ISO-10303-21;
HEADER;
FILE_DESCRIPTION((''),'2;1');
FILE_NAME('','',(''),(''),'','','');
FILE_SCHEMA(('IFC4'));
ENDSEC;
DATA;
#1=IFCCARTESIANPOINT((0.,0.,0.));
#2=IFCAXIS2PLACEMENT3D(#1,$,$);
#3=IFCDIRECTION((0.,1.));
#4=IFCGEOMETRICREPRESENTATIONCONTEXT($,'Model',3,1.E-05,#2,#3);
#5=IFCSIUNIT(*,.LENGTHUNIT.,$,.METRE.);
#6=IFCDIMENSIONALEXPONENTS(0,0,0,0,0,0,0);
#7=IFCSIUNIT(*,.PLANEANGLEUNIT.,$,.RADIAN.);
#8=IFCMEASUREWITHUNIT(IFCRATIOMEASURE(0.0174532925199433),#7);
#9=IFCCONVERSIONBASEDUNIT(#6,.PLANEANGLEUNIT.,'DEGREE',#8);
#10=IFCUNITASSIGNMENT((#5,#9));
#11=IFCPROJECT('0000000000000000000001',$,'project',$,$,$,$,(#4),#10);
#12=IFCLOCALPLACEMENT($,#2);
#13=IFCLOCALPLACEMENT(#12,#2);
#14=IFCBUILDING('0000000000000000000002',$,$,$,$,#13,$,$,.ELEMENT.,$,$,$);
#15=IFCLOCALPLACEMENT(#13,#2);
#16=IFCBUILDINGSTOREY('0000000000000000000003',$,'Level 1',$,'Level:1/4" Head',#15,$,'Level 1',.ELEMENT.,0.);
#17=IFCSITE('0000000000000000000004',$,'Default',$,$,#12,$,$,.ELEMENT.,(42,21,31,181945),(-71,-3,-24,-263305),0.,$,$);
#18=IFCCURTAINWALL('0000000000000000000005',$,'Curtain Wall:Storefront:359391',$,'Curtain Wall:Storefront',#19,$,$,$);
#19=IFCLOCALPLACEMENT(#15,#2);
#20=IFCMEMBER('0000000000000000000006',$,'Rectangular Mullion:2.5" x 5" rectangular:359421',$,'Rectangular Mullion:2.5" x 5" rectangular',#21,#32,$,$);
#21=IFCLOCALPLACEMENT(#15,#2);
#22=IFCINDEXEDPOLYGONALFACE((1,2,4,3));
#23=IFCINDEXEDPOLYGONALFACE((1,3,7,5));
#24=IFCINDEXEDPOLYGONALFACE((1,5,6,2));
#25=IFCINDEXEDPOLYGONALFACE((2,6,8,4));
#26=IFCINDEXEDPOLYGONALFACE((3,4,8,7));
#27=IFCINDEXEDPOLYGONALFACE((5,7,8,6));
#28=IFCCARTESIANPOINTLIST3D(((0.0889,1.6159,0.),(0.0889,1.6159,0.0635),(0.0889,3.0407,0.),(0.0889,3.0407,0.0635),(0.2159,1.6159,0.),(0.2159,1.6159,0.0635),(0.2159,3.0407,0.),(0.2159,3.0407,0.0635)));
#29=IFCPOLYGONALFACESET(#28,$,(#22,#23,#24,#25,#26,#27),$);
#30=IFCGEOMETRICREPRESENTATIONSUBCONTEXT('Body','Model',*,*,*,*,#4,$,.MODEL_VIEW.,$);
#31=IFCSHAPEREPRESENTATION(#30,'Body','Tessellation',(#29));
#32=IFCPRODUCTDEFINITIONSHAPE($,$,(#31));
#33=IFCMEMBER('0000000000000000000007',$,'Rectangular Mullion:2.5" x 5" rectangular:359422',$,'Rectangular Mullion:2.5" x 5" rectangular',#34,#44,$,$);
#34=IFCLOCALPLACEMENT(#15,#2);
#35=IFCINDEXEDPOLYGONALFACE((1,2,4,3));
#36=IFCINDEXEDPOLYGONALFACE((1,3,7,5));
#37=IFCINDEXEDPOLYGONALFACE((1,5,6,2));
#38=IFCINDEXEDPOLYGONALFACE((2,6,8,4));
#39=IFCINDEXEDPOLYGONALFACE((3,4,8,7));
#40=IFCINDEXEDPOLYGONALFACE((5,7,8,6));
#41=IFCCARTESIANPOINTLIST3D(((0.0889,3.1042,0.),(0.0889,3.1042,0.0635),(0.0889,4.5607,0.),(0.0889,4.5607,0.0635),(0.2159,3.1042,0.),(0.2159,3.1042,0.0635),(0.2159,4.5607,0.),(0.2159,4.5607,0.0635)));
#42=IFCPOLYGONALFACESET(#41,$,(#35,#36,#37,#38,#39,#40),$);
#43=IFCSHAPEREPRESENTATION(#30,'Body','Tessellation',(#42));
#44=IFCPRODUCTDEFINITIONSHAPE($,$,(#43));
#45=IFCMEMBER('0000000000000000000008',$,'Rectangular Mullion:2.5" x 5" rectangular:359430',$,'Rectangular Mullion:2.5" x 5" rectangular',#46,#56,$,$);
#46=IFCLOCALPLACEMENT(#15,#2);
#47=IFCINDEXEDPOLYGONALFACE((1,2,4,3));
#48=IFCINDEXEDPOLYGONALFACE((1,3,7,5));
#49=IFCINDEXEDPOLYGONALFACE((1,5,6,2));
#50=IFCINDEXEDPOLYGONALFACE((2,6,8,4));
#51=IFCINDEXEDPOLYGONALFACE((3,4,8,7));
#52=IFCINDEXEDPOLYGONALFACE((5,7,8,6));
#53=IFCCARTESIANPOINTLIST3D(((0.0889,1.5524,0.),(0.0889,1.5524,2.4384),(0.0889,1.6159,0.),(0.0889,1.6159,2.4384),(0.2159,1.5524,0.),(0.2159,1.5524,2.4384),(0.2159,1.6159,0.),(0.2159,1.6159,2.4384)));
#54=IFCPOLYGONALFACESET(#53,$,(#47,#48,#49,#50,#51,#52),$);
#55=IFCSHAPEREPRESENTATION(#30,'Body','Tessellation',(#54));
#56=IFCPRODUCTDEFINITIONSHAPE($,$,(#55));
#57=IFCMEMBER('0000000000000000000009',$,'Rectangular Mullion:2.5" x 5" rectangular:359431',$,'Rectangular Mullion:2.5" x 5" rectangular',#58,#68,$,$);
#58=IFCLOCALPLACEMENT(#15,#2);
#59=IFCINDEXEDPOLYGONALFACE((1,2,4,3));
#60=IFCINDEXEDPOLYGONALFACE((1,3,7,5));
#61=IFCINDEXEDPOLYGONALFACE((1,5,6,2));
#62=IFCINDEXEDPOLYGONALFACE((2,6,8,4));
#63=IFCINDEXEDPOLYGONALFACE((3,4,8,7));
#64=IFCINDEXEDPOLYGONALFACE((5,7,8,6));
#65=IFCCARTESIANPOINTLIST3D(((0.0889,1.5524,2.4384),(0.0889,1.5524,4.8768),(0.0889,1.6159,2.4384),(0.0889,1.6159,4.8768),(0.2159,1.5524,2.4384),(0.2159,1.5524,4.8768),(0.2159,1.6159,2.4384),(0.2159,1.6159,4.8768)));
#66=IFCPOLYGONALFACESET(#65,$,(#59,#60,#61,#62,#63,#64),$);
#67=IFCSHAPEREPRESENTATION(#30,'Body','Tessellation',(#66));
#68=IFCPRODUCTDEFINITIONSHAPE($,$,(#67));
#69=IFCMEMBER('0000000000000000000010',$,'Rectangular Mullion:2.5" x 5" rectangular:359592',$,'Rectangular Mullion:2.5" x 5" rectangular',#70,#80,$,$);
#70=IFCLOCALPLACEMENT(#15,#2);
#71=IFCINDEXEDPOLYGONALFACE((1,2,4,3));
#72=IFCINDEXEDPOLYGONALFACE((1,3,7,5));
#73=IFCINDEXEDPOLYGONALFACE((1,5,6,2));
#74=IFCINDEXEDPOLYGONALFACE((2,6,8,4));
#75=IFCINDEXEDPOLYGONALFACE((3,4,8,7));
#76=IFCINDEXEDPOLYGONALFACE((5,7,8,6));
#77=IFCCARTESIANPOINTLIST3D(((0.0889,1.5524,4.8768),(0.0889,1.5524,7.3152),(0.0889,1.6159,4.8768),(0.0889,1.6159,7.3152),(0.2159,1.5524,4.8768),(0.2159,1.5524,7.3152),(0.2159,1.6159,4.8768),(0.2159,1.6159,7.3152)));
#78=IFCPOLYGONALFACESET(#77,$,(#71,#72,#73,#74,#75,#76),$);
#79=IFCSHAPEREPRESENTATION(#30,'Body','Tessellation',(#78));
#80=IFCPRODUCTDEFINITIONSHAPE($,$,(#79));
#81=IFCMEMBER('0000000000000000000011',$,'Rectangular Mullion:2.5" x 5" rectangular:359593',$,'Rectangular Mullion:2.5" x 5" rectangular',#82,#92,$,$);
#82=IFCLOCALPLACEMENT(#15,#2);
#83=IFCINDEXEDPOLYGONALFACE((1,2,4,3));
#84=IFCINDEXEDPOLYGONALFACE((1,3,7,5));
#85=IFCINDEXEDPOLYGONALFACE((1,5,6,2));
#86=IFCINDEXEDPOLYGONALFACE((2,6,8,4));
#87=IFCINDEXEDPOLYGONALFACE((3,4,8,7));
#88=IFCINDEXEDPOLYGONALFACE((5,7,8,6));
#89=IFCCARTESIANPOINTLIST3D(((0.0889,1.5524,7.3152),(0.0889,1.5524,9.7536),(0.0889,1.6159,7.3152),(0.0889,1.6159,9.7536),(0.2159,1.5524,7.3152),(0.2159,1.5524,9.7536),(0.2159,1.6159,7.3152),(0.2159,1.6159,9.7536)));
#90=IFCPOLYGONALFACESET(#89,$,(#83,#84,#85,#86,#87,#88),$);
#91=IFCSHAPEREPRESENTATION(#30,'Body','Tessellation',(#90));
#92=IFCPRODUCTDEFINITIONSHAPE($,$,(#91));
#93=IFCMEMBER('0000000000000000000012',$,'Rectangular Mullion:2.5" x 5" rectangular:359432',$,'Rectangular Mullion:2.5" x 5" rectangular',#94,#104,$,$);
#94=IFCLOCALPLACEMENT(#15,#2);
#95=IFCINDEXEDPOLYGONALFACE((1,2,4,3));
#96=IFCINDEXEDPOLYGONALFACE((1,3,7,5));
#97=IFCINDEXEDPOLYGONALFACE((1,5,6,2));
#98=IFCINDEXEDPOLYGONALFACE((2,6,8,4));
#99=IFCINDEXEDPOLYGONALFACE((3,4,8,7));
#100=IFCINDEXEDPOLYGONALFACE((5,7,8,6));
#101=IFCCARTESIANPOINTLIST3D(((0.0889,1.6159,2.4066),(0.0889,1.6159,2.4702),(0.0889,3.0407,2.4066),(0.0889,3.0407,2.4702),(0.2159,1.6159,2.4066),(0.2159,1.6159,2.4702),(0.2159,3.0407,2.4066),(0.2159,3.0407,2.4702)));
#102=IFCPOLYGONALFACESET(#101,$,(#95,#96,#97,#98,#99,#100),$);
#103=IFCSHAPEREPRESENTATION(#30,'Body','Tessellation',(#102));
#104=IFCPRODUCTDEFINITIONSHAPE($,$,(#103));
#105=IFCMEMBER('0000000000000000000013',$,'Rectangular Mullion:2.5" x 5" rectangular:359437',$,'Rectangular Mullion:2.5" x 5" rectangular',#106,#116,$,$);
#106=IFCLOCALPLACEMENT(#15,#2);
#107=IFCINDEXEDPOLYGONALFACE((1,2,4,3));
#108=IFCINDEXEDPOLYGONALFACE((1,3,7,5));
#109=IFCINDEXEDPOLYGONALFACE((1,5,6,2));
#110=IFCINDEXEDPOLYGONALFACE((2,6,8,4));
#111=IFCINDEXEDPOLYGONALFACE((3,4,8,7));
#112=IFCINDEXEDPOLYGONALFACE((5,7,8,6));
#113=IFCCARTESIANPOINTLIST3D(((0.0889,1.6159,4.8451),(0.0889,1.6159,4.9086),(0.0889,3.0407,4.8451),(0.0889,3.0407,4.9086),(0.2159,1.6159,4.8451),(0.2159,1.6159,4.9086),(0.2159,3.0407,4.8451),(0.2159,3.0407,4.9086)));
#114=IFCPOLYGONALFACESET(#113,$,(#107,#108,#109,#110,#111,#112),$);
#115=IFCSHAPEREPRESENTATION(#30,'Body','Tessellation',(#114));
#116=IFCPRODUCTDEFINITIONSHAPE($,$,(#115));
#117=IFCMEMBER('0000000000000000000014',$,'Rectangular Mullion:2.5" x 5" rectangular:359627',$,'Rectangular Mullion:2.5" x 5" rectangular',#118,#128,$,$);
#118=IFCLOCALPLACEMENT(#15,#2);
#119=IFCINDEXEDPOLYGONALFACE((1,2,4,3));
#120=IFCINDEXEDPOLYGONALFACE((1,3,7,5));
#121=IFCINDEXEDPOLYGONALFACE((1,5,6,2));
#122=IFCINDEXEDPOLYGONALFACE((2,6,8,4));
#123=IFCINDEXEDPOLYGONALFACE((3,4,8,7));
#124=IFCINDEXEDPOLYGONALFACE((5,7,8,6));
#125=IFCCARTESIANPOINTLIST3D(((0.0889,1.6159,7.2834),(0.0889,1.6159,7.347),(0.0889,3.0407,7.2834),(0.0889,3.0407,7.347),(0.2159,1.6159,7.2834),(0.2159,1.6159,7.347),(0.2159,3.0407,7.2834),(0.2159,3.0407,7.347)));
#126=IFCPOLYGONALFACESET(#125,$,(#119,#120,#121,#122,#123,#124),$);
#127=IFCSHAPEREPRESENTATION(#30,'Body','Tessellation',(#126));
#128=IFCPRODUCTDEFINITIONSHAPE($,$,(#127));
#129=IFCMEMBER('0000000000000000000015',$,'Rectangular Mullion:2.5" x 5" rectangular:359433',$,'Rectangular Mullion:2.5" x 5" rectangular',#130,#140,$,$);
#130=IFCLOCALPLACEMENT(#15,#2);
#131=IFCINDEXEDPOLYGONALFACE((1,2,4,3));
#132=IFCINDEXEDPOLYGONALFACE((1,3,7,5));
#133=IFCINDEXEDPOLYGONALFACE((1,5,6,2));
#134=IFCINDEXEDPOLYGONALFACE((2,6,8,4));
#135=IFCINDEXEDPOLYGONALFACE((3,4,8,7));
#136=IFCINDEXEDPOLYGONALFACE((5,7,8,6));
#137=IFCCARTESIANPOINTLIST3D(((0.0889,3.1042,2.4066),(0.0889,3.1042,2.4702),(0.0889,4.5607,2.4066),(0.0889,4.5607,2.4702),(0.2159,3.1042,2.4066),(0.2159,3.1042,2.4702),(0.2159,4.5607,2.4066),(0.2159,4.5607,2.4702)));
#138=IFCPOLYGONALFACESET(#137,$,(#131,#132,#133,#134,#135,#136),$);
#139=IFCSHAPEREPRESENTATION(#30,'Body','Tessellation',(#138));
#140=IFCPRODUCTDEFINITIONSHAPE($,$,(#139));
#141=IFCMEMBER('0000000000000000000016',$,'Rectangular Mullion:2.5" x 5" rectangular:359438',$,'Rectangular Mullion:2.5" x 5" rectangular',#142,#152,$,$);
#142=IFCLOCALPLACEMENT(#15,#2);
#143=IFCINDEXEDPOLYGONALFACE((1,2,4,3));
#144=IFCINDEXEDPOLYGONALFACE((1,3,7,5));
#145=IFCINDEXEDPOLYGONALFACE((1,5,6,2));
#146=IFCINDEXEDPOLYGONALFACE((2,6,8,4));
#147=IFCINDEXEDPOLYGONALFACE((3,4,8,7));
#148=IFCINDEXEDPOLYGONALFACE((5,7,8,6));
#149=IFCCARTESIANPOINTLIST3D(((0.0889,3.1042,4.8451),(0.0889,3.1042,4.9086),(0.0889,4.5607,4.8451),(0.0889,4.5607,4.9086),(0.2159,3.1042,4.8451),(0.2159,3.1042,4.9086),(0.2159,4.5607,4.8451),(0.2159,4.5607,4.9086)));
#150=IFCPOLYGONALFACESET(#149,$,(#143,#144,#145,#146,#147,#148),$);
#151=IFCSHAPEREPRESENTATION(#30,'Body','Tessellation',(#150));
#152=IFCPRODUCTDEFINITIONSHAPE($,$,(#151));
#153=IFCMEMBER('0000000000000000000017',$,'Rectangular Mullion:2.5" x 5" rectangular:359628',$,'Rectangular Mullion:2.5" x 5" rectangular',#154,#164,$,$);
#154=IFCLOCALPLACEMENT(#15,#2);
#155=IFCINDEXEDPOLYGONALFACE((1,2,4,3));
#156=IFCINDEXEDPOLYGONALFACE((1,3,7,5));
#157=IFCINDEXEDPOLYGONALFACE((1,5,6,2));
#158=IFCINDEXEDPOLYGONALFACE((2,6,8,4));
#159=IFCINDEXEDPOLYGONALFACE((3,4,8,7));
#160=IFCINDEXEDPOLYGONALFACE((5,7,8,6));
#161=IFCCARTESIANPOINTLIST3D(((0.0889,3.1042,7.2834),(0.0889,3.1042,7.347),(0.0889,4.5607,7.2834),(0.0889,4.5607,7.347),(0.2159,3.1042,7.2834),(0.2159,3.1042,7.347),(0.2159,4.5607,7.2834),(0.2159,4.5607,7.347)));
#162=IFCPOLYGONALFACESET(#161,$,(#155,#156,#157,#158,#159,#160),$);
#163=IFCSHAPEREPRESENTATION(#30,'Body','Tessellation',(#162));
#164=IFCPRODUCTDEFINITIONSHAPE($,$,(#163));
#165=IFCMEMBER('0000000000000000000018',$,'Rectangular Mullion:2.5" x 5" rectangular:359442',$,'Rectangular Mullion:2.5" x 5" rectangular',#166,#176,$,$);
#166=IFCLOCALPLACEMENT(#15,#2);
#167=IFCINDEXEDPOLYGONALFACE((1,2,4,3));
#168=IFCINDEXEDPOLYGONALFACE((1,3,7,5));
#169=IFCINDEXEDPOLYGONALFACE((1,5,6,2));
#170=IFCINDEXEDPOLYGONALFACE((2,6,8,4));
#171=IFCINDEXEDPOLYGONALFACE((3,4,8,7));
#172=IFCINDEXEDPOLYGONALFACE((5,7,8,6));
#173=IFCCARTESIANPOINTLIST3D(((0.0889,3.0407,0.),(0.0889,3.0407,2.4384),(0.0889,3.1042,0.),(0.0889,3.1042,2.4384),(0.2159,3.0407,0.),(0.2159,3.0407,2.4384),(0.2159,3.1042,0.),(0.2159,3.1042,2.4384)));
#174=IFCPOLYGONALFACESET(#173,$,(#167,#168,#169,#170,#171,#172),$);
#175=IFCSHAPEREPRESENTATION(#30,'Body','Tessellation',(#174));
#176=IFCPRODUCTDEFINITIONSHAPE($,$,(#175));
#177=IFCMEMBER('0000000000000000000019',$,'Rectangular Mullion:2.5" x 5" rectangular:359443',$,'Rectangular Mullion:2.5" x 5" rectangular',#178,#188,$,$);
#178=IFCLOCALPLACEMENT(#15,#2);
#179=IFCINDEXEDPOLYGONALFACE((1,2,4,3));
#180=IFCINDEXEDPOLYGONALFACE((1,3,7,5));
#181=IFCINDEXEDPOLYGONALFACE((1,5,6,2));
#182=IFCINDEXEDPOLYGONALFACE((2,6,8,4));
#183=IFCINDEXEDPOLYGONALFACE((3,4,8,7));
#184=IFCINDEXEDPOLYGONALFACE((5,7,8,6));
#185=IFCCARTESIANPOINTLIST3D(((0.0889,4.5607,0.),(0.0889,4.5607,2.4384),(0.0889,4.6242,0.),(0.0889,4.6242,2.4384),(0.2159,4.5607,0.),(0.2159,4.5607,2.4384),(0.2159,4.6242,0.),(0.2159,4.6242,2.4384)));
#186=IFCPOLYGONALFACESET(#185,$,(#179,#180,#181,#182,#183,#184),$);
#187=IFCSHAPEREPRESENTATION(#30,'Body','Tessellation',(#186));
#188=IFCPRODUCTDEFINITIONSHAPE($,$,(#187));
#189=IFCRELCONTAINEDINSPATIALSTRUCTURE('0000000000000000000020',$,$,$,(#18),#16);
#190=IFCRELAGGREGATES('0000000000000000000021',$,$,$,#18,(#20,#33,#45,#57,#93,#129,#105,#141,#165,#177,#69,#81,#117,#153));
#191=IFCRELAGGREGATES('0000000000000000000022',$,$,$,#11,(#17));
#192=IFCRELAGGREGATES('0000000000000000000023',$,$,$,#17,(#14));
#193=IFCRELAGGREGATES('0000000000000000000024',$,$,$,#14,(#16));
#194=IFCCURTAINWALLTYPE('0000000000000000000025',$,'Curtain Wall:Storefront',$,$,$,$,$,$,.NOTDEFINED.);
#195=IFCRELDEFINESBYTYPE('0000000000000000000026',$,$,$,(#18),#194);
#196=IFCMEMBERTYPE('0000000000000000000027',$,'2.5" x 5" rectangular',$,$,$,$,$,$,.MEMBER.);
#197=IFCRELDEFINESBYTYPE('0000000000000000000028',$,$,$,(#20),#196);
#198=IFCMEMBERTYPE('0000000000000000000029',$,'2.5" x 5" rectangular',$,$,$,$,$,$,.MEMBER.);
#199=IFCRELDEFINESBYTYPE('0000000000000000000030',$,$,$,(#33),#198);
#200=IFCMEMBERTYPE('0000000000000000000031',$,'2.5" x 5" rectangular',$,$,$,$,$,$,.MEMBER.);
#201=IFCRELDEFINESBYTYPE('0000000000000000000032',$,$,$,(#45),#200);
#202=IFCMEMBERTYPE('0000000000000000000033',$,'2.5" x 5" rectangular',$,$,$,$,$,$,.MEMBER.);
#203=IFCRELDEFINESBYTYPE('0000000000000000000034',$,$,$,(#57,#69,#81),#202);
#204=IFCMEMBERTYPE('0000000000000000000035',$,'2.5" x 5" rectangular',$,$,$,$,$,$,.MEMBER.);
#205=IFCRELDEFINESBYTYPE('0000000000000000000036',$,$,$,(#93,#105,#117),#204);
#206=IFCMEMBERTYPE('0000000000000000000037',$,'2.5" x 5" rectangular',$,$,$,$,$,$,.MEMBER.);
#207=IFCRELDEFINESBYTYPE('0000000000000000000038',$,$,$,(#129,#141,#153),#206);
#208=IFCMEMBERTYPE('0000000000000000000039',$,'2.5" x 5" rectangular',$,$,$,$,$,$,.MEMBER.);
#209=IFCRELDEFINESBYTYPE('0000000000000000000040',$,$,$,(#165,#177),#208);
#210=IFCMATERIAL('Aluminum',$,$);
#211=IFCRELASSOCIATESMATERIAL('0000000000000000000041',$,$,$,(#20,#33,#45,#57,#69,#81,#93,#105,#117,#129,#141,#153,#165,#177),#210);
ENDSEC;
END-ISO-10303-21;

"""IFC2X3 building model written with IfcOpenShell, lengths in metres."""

from ifc_helpers import new_model, entity, si_unit, converted_unit, direction, frame, origin, origin_2d_with_axis, place, context, subcontext, project, spatial, rectangle, extrude, source, transform, mapped, material, type_object, type_shapes, element, aggregate, save


model = new_model("IFC2X3")

# Units and contexts
model_context = context("Model", 3, precision=1e-05, world=origin(), true_north=direction((0.0, 1.0)))
body_context = subcontext(model_context, "Body", "Model", "MODEL_VIEW")
ifc_project = project(units=[si_unit("LENGTHUNIT", "METRE"), converted_unit("PLANEANGLEUNIT", "DEGREE", entity("IfcRatioMeasure", 0.0174532925199433), si_unit("PLANEANGLEUNIT", "RADIAN"), dimensions=[0, 0, 0, 0, 0, 0, 0])], contexts=[model_context])

# Site, building, storey
site_placement = place(None, origin())
site = spatial("IfcSite", under=ifc_project, at=site_placement, Name="Default", CompositionType="ELEMENT", RefLatitude=(42, 21, 31, 181945), RefLongitude=(-71, -3, -24, -263305), RefElevation=0.0)
building_placement = place(site_placement, origin())
building = spatial("IfcBuilding", under=site, at=building_placement, CompositionType="ELEMENT")
storey_placement = place(building_placement, origin())
storey = spatial("IfcBuildingStorey", under=building, at=storey_placement, Name="Level 1", ObjectType="Level:1/4\" Head", LongName="Level 1", CompositionType="ELEMENT", Elevation=0.0)

# Curtain wall, members
curtain_wall_type = type_object("IfcCurtainWallType", Name="Curtain Wall:Storefront", PredefinedType="NOTDEFINED")
curtain_wall_placement = place(storey_placement, origin())
curtain_wall = element("IfcCurtainWall", 1, at=curtain_wall_placement, inside=storey, type_object=curtain_wall_type, Name="Curtain Wall:Storefront:359391", ObjectType="Curtain Wall:Storefront")
ifc_material_1 = material(Name="Aluminum")
member_type_1 = type_object("IfcMemberType", Name="2.5\" x 5\" rectangular", PredefinedType="MEMBER")
shared_shape_1 = source(origin(), body_context, "Body", "SweptSolid", [
    extrude(rectangle(XDim=0.127, YDim=0.0635, at=origin_2d_with_axis()), frame((-0.0318, 0.0, -1.4248), z_axis=(0.0, 0.0, 1.0), x_axis=(0.0, -1.0, 0.0)), (0.0, 0.0, 1.0), 1.4248),
])
type_shapes(member_type_1, [shared_shape_1])
member_1_placement = place(storey_placement, frame((0.1524, 1.6159, 0.0), z_axis=(0.0, -1.0, 0.0), x_axis=(0.0, 0.0, -1.0)))
member_1 = element("IfcMember", 2, at=member_1_placement, type_object=member_type_1, material=ifc_material_1, Name="Rectangular Mullion:2.5\" x 5\" rectangular:359421", ObjectType="Rectangular Mullion:2.5\" x 5\" rectangular", context=body_context, shape_type="MappedRepresentation", body=[
    mapped(shared_shape_1, transform((0.0, 0.0, 0.0), scale=1.0)),
])
member_type_2 = type_object("IfcMemberType", Name="2.5\" x 5\" rectangular", PredefinedType="MEMBER")
shared_shape_2 = source(origin(), body_context, "Body", "SweptSolid", [
    extrude(rectangle(XDim=0.127, YDim=0.0635, at=origin_2d_with_axis()), frame((-0.0318, 0.0, -1.4565), z_axis=(0.0, 0.0, 1.0), x_axis=(0.0, -1.0, 0.0)), (0.0, 0.0, 1.0), 1.4565),
])
type_shapes(member_type_2, [shared_shape_2])
member_2_placement = place(storey_placement, frame((0.1524, 3.1042, 0.0), z_axis=(0.0, -1.0, 0.0), x_axis=(0.0, 0.0, -1.0)))
member_2 = element("IfcMember", 3, at=member_2_placement, type_object=member_type_2, material=ifc_material_1, Name="Rectangular Mullion:2.5\" x 5\" rectangular:359422", ObjectType="Rectangular Mullion:2.5\" x 5\" rectangular", context=body_context, shape_type="MappedRepresentation", body=[
    mapped(shared_shape_2, transform((0.0, 0.0, 0.0), scale=1.0)),
])
member_type_3 = type_object("IfcMemberType", Name="2.5\" x 5\" rectangular", PredefinedType="MEMBER")
shared_shape_3 = source(origin(), body_context, "Body", "SweptSolid", [
    extrude(rectangle(XDim=0.127, YDim=0.0635, at=origin_2d_with_axis()), frame((-0.0318, 0.0, -2.4384), z_axis=(0.0, 0.0, 1.0), x_axis=(0.0, -1.0, 0.0)), (0.0, 0.0, 1.0), 2.4384),
])
type_shapes(member_type_3, [shared_shape_3])
member_3_placement = place(storey_placement, frame((0.1524, 1.5524, 2.4384), z_axis=(0.0, 0.0, 1.0), x_axis=(0.0, -1.0, 0.0)))
member_3 = element("IfcMember", 4, at=member_3_placement, type_object=member_type_3, material=ifc_material_1, Name="Rectangular Mullion:2.5\" x 5\" rectangular:359430", ObjectType="Rectangular Mullion:2.5\" x 5\" rectangular", context=body_context, shape_type="MappedRepresentation", body=[
    mapped(shared_shape_3, transform((0.0, 0.0, 0.0), scale=1.0)),
])
member_type_4 = type_object("IfcMemberType", Name="2.5\" x 5\" rectangular", PredefinedType="MEMBER")
shared_shape_4 = source(origin(), body_context, "Body", "SweptSolid", [
    extrude(rectangle(XDim=0.127, YDim=0.0635, at=origin_2d_with_axis()), frame((-0.0318, 0.0, -2.4384), z_axis=(0.0, 0.0, 1.0), x_axis=(0.0, -1.0, 0.0)), (0.0, 0.0, 1.0), 2.4384),
])
type_shapes(member_type_4, [shared_shape_4])
member_4_placement = place(storey_placement, frame((0.1524, 1.5524, 4.8768), z_axis=(0.0, 0.0, 1.0), x_axis=(0.0, -1.0, 0.0)))
member_4 = element("IfcMember", 5, at=member_4_placement, type_object=member_type_4, material=ifc_material_1, Name="Rectangular Mullion:2.5\" x 5\" rectangular:359431", ObjectType="Rectangular Mullion:2.5\" x 5\" rectangular", context=body_context, shape_type="MappedRepresentation", body=[
    mapped(shared_shape_4, transform((0.0, 0.0, 0.0), scale=1.0)),
])
member_5_placement = place(storey_placement, frame((0.1524, 1.5524, 7.3152), z_axis=(0.0, 0.0, 1.0), x_axis=(0.0, -1.0, 0.0)))
member_5 = element("IfcMember", 6, at=member_5_placement, type_object=member_type_4, material=ifc_material_1, Name="Rectangular Mullion:2.5\" x 5\" rectangular:359592", ObjectType="Rectangular Mullion:2.5\" x 5\" rectangular", context=body_context, shape_type="MappedRepresentation", body=[
    mapped(shared_shape_4, transform((0.0, 0.0, 0.0), scale=1.0)),
])
member_6_placement = place(storey_placement, frame((0.1524, 1.5524, 9.7536), z_axis=(0.0, 0.0, 1.0), x_axis=(0.0, -1.0, 0.0)))
member_6 = element("IfcMember", 7, at=member_6_placement, type_object=member_type_4, material=ifc_material_1, Name="Rectangular Mullion:2.5\" x 5\" rectangular:359593", ObjectType="Rectangular Mullion:2.5\" x 5\" rectangular", context=body_context, shape_type="MappedRepresentation", body=[
    mapped(shared_shape_4, transform((0.0, 0.0, 0.0), scale=1.0)),
])
member_type_5 = type_object("IfcMemberType", Name="2.5\" x 5\" rectangular", PredefinedType="MEMBER")
shared_shape_5 = source(origin(), body_context, "Body", "SweptSolid", [
    extrude(rectangle(XDim=0.127, YDim=0.0635, at=origin_2d_with_axis()), frame((0.0, 0.0, -1.4248), z_axis=(0.0, 0.0, 1.0), x_axis=(0.0, -1.0, 0.0)), (0.0, 0.0, 1.0), 1.4248),
])
type_shapes(member_type_5, [shared_shape_5])
member_7_placement = place(storey_placement, frame((0.1524, 3.0407, 2.4384), z_axis=(0.0, 1.0, 0.0), x_axis=(0.0, 0.0, 1.0)))
member_7 = element("IfcMember", 8, at=member_7_placement, type_object=member_type_5, material=ifc_material_1, Name="Rectangular Mullion:2.5\" x 5\" rectangular:359432", ObjectType="Rectangular Mullion:2.5\" x 5\" rectangular", context=body_context, shape_type="MappedRepresentation", body=[
    mapped(shared_shape_5, transform((0.0, 0.0, 0.0), scale=1.0)),
])
member_8_placement = place(storey_placement, frame((0.1524, 3.0407, 4.8768), z_axis=(0.0, 1.0, 0.0), x_axis=(0.0, 0.0, 1.0)))
member_8 = element("IfcMember", 9, at=member_8_placement, type_object=member_type_5, material=ifc_material_1, Name="Rectangular Mullion:2.5\" x 5\" rectangular:359437", ObjectType="Rectangular Mullion:2.5\" x 5\" rectangular", context=body_context, shape_type="MappedRepresentation", body=[
    mapped(shared_shape_5, transform((0.0, 0.0, 0.0), scale=1.0)),
])
member_9_placement = place(storey_placement, frame((0.1524, 3.0407, 7.3152), z_axis=(0.0, 1.0, 0.0), x_axis=(0.0, 0.0, 1.0)))
member_9 = element("IfcMember", 10, at=member_9_placement, type_object=member_type_5, material=ifc_material_1, Name="Rectangular Mullion:2.5\" x 5\" rectangular:359627", ObjectType="Rectangular Mullion:2.5\" x 5\" rectangular", context=body_context, shape_type="MappedRepresentation", body=[
    mapped(shared_shape_5, transform((0.0, 0.0, 0.0), scale=1.0)),
])
member_type_6 = type_object("IfcMemberType", Name="2.5\" x 5\" rectangular", PredefinedType="MEMBER")
shared_shape_6 = source(origin(), body_context, "Body", "SweptSolid", [
    extrude(rectangle(XDim=0.127, YDim=0.0635, at=origin_2d_with_axis()), frame((0.0, 0.0, -1.4565), z_axis=(0.0, 0.0, 1.0), x_axis=(0.0, -1.0, 0.0)), (0.0, 0.0, 1.0), 1.4565),
])
type_shapes(member_type_6, [shared_shape_6])
member_10_placement = place(storey_placement, frame((0.1524, 4.5607, 2.4384), z_axis=(0.0, 1.0, 0.0), x_axis=(0.0, 0.0, 1.0)))
member_10 = element("IfcMember", 11, at=member_10_placement, type_object=member_type_6, material=ifc_material_1, Name="Rectangular Mullion:2.5\" x 5\" rectangular:359433", ObjectType="Rectangular Mullion:2.5\" x 5\" rectangular", context=body_context, shape_type="MappedRepresentation", body=[
    mapped(shared_shape_6, transform((0.0, 0.0, 0.0), scale=1.0)),
])
member_11_placement = place(storey_placement, frame((0.1524, 4.5607, 4.8768), z_axis=(0.0, 1.0, 0.0), x_axis=(0.0, 0.0, 1.0)))
member_11 = element("IfcMember", 12, at=member_11_placement, type_object=member_type_6, material=ifc_material_1, Name="Rectangular Mullion:2.5\" x 5\" rectangular:359438", ObjectType="Rectangular Mullion:2.5\" x 5\" rectangular", context=body_context, shape_type="MappedRepresentation", body=[
    mapped(shared_shape_6, transform((0.0, 0.0, 0.0), scale=1.0)),
])
member_12_placement = place(storey_placement, frame((0.1524, 4.5607, 7.3152), z_axis=(0.0, 1.0, 0.0), x_axis=(0.0, 0.0, 1.0)))
member_12 = element("IfcMember", 13, at=member_12_placement, type_object=member_type_6, material=ifc_material_1, Name="Rectangular Mullion:2.5\" x 5\" rectangular:359628", ObjectType="Rectangular Mullion:2.5\" x 5\" rectangular", context=body_context, shape_type="MappedRepresentation", body=[
    mapped(shared_shape_6, transform((0.0, 0.0, 0.0), scale=1.0)),
])
member_type_7 = type_object("IfcMemberType", Name="2.5\" x 5\" rectangular", PredefinedType="MEMBER")
shared_shape_7 = source(origin(), body_context, "Body", "SweptSolid", [
    extrude(rectangle(XDim=0.127, YDim=0.0635, at=origin_2d_with_axis()), frame((0.0, 0.0, -2.4384), z_axis=(0.0, 0.0, 1.0), x_axis=(0.0, -1.0, 0.0)), (0.0, 0.0, 1.0), 2.4384),
])
type_shapes(member_type_7, [shared_shape_7])
member_13_placement = place(storey_placement, frame((0.1524, 3.0724, 0.0), z_axis=(0.0, 0.0, -1.0), x_axis=(0.0, 1.0, 0.0)))
member_13 = element("IfcMember", 14, at=member_13_placement, type_object=member_type_7, material=ifc_material_1, Name="Rectangular Mullion:2.5\" x 5\" rectangular:359442", ObjectType="Rectangular Mullion:2.5\" x 5\" rectangular", context=body_context, shape_type="MappedRepresentation", body=[
    mapped(shared_shape_7, transform((0.0, 0.0, 0.0), scale=1.0)),
])
member_14_placement = place(storey_placement, frame((0.1524, 4.5924, 0.0), z_axis=(0.0, 0.0, -1.0), x_axis=(0.0, 1.0, 0.0)))
member_14 = element("IfcMember", 15, at=member_14_placement, type_object=member_type_7, material=ifc_material_1, Name="Rectangular Mullion:2.5\" x 5\" rectangular:359443", ObjectType="Rectangular Mullion:2.5\" x 5\" rectangular", context=body_context, shape_type="MappedRepresentation", body=[
    mapped(shared_shape_7, transform((0.0, 0.0, 0.0), scale=1.0)),
])

aggregate(curtain_wall, [member_1, member_2, member_3, member_4, member_7, member_10, member_8, member_11, member_13, member_14, member_5, member_6, member_9, member_12])

save(model, "model.ifc")
